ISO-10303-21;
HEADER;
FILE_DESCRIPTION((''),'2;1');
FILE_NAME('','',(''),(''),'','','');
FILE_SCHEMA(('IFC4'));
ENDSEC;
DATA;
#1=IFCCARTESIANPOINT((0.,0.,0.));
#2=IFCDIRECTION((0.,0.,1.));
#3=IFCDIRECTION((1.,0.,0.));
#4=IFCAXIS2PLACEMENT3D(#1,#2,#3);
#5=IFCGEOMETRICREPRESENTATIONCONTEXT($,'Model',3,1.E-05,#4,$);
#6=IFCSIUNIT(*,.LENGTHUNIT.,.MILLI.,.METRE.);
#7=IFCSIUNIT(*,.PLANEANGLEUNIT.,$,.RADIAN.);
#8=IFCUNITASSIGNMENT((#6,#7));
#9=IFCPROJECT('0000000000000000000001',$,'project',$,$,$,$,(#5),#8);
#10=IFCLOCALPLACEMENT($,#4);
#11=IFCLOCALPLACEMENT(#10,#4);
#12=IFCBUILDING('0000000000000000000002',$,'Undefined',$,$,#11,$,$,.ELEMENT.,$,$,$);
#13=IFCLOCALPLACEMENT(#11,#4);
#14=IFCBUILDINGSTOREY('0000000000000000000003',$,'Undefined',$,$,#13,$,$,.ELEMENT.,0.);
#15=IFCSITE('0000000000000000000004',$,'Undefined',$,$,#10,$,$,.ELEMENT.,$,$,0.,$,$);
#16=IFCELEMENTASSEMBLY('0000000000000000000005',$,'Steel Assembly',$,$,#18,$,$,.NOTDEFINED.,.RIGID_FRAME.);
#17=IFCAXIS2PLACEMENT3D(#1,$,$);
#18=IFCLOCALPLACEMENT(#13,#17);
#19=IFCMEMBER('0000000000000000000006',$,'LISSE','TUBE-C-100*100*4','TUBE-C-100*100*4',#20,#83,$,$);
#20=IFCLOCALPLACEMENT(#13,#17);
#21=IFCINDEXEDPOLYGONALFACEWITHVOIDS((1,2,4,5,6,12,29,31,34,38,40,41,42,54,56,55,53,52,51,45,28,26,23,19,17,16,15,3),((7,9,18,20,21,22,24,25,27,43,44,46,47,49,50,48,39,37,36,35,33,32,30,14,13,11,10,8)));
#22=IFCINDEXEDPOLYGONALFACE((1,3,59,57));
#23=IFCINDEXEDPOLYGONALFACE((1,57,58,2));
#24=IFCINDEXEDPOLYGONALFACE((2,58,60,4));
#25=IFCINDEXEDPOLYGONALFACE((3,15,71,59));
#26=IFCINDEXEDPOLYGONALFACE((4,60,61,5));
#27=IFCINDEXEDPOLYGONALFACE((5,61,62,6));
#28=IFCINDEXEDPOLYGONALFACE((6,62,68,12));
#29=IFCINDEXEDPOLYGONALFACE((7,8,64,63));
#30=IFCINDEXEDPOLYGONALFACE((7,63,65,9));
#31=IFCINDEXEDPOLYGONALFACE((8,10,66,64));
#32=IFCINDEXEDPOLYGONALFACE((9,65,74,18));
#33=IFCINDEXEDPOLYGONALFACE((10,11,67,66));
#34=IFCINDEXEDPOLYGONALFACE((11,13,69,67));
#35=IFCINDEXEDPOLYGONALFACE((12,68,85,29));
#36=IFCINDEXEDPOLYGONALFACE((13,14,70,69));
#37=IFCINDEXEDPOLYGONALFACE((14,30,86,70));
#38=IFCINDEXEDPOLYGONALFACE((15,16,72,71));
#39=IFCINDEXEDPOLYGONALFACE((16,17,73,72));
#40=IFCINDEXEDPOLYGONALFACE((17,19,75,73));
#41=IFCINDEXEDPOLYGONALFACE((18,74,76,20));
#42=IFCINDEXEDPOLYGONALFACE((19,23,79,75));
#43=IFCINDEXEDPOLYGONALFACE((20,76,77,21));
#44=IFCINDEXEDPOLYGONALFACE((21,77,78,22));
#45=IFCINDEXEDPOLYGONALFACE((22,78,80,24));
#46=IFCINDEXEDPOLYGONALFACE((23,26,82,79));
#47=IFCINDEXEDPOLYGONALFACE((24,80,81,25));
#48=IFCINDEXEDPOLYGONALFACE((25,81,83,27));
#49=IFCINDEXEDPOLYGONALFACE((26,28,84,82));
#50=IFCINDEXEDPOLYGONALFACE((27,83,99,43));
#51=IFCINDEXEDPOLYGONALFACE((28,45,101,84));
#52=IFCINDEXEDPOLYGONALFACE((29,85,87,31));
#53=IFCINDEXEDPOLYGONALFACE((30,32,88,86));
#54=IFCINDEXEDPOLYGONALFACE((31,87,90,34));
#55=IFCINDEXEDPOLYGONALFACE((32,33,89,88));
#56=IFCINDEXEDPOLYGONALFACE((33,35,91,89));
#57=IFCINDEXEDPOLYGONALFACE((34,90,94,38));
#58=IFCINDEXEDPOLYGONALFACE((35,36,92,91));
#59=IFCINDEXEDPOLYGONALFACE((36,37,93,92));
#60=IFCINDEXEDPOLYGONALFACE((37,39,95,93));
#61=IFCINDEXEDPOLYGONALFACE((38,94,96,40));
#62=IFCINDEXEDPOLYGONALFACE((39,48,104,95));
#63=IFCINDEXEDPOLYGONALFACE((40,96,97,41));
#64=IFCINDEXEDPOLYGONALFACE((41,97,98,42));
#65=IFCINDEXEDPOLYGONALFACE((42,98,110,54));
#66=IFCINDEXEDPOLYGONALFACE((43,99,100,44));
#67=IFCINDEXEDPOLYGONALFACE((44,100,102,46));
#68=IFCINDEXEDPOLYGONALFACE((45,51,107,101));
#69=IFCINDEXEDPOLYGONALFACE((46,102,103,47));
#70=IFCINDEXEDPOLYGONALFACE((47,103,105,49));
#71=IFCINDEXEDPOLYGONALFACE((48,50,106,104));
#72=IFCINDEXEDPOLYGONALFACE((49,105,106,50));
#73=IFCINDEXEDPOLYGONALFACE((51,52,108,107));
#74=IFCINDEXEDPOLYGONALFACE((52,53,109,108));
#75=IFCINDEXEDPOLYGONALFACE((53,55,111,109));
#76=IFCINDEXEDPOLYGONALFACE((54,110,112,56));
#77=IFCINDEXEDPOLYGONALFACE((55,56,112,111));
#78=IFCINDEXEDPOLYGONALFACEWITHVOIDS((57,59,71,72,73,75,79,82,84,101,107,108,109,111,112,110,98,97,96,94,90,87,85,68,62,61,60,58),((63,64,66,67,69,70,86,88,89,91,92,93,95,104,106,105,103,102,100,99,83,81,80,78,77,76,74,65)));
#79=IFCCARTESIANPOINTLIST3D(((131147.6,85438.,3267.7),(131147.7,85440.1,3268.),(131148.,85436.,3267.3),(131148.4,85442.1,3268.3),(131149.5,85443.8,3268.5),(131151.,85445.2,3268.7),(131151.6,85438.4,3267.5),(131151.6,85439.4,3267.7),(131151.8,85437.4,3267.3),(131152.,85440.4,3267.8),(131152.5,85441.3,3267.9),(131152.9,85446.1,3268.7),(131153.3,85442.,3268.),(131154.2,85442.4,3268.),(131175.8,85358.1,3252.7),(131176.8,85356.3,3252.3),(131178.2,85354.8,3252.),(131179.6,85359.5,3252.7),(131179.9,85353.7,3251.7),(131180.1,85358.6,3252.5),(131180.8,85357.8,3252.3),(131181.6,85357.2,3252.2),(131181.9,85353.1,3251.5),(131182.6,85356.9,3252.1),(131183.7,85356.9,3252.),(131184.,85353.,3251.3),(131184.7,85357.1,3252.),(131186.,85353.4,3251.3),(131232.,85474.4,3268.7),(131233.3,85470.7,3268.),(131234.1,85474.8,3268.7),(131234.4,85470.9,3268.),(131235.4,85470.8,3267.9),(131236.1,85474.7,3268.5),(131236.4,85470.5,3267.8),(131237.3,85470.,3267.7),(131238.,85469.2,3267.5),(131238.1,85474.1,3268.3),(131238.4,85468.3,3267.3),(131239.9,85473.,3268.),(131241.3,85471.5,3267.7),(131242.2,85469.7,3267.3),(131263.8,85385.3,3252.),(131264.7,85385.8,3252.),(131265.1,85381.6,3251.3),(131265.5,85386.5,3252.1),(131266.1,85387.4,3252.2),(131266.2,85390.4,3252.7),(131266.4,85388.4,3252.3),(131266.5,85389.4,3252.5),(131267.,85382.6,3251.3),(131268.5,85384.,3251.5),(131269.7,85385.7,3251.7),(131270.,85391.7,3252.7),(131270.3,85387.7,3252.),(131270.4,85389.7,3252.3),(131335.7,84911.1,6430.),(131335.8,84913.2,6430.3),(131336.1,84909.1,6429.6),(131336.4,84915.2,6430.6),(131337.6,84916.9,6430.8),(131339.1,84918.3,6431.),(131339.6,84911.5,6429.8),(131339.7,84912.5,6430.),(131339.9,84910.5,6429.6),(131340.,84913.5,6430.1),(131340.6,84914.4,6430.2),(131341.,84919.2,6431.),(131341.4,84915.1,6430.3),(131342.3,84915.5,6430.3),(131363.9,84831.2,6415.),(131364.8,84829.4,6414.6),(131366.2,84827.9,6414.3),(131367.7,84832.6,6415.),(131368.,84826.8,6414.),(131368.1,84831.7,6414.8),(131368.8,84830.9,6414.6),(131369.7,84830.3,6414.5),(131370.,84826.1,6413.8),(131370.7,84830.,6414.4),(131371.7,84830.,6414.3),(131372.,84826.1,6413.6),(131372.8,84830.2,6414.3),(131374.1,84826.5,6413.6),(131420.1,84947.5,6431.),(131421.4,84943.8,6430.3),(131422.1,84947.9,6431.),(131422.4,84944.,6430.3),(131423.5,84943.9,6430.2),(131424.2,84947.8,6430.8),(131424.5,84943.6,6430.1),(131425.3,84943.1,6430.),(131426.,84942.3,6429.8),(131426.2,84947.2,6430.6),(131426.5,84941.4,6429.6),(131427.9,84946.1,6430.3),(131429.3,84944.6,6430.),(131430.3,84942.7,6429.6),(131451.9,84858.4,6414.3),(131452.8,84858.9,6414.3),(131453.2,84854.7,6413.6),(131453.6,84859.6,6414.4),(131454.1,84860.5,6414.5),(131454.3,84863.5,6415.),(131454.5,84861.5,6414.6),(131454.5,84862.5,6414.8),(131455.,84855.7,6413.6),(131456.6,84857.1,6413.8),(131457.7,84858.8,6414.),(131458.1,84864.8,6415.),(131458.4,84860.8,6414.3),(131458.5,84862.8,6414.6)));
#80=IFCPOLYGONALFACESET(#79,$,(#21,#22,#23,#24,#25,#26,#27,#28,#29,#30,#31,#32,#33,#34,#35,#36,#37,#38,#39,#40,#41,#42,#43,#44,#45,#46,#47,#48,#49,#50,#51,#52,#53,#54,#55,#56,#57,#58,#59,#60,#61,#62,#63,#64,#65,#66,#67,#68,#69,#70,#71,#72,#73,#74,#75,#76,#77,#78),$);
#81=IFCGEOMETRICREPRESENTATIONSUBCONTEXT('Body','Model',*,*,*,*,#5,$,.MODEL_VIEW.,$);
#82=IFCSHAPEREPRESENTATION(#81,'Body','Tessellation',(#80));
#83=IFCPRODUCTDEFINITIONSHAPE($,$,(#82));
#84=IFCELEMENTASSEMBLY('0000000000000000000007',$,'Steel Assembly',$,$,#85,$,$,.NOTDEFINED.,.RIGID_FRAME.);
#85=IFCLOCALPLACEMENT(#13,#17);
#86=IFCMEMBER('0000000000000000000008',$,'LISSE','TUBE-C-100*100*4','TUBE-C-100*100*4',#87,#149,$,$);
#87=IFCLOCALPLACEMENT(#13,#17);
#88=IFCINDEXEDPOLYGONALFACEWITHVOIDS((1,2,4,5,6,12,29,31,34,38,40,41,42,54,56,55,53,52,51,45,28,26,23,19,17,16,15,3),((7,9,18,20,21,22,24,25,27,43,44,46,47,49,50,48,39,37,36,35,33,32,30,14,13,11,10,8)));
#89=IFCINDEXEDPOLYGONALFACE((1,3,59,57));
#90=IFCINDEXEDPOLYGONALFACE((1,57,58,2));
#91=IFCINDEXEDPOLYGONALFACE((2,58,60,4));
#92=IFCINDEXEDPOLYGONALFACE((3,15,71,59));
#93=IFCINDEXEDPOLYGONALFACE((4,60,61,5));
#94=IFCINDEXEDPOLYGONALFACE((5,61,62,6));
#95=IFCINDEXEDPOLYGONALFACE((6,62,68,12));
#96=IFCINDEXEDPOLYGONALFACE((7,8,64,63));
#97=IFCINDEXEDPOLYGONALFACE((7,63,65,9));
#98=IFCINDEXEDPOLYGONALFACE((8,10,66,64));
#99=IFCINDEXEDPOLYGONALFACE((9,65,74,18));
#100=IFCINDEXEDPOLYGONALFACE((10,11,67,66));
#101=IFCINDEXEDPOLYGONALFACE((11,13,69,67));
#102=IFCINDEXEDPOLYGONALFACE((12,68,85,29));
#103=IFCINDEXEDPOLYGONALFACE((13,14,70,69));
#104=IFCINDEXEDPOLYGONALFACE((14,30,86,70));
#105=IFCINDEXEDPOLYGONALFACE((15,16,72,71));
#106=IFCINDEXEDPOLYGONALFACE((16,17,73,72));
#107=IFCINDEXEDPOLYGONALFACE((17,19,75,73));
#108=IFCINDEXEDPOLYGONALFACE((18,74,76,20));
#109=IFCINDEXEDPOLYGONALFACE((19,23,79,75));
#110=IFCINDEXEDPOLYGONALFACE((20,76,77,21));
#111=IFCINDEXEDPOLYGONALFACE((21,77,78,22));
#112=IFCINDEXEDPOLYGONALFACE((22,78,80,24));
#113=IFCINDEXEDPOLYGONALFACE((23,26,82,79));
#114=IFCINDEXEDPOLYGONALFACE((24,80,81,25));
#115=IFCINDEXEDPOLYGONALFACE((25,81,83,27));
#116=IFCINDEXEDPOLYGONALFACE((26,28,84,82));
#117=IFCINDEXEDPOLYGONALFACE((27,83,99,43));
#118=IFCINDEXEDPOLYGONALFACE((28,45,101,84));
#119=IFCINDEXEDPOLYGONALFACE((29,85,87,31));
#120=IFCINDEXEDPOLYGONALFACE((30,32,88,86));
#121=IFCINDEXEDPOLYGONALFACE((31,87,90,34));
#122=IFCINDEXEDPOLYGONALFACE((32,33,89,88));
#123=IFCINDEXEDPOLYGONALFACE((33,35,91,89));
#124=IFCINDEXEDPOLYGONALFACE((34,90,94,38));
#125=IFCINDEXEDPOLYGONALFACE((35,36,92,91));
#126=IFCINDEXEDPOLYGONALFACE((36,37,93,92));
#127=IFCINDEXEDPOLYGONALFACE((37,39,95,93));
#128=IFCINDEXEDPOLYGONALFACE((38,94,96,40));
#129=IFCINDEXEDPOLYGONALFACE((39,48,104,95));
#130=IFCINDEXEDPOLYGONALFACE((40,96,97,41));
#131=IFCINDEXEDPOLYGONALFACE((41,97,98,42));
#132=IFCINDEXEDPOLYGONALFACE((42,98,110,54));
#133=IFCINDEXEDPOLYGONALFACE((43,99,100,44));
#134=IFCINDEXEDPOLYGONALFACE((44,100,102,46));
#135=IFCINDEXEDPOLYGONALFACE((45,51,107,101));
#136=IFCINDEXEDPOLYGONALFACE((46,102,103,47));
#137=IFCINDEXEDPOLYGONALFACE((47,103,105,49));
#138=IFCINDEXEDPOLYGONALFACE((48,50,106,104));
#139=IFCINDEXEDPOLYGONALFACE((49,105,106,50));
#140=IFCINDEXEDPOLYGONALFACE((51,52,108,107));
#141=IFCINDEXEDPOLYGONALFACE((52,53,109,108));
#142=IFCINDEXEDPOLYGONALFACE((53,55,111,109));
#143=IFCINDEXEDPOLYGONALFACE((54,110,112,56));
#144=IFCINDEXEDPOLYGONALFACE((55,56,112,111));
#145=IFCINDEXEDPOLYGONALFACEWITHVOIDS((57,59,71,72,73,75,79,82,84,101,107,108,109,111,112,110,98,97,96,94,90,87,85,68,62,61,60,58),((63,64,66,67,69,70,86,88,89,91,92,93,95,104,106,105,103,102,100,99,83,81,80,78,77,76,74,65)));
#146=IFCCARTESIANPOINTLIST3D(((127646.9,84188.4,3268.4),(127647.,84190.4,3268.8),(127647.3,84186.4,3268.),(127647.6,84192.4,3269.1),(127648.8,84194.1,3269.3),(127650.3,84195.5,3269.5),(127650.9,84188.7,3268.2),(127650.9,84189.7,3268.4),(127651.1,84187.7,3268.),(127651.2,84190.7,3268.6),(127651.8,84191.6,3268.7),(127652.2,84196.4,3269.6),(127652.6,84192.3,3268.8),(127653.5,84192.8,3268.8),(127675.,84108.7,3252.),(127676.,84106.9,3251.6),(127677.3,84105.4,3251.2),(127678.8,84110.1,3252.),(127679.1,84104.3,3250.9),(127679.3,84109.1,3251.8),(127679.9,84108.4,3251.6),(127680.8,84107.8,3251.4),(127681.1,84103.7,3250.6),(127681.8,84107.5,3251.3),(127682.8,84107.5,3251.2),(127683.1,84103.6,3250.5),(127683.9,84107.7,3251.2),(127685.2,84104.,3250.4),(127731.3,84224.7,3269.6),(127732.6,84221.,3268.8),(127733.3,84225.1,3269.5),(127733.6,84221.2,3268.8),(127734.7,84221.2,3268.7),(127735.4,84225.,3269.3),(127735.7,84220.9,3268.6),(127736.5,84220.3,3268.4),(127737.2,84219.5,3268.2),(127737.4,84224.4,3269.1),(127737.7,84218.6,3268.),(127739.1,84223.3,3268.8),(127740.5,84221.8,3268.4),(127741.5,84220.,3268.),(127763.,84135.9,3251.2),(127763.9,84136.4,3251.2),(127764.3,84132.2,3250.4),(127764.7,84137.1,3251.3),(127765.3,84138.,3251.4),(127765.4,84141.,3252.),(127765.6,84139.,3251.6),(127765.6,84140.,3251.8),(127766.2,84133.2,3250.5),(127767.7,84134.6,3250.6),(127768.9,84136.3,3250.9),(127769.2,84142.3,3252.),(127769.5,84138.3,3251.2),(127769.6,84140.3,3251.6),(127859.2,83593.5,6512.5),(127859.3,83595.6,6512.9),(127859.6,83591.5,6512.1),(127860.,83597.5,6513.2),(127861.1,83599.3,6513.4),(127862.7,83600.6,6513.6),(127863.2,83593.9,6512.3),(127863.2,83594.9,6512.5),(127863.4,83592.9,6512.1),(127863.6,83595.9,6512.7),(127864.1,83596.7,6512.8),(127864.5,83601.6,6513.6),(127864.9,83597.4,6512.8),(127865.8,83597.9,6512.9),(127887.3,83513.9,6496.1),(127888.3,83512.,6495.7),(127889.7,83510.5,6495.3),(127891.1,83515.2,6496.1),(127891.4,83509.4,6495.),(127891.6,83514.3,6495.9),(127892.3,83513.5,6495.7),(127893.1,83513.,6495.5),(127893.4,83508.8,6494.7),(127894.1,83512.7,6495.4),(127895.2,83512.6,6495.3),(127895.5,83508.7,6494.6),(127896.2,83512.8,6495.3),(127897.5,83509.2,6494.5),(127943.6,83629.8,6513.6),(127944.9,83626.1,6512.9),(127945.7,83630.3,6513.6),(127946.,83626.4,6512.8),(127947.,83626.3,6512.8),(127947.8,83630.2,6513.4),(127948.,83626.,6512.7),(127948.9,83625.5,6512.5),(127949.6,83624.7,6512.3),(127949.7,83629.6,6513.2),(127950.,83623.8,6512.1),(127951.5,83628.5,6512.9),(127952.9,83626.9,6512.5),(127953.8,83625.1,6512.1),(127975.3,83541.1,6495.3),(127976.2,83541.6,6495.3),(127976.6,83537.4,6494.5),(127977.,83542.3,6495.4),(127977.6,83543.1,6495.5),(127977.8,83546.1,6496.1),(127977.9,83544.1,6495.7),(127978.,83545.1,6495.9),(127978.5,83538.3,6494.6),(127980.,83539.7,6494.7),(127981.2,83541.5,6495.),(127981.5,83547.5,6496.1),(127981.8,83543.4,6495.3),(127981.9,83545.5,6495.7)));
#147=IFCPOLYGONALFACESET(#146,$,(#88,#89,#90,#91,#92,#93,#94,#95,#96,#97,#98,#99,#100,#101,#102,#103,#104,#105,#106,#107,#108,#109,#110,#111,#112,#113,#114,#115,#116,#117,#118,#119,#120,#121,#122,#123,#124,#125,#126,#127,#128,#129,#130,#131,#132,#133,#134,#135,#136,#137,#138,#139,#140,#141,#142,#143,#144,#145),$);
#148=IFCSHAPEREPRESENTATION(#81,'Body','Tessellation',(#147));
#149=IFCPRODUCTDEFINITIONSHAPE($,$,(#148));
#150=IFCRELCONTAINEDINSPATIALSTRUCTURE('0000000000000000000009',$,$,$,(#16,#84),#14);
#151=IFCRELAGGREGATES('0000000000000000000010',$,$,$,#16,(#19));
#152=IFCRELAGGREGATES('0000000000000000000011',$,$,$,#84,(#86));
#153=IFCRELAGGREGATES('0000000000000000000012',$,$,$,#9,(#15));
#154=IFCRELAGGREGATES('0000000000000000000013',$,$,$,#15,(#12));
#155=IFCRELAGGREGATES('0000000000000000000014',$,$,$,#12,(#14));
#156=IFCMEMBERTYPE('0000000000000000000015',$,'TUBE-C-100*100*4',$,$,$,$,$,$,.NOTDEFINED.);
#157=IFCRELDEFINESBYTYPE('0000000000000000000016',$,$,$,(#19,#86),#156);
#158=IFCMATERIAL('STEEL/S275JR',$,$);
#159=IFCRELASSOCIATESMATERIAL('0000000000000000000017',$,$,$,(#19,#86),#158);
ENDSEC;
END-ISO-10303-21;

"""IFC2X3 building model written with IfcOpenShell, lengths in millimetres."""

from ifc_helpers import new_model, si_unit, frame, origin_with_axes, origin_2d_with_axis, place, context, subcontext, project, spatial, hollow_rectangle, extrude, material, type_object, element, aggregate, save


model = new_model("IFC2X3")

# Units and contexts
model_context = context("Model", 3, precision=1e-05, world=origin_with_axes())
body_context = subcontext(model_context, "Body", "Model", "MODEL_VIEW")
ifc_project = project(units=[si_unit("LENGTHUNIT", "METRE", prefix="MILLI"), si_unit("PLANEANGLEUNIT", "RADIAN")], contexts=[model_context])

# Site, building, storey
site_placement = place(None, origin_with_axes())
site = spatial("IfcSite", under=ifc_project, at=site_placement, Name="Undefined", CompositionType="ELEMENT", RefElevation=0.0)
building_placement = place(site_placement, origin_with_axes())
building = spatial("IfcBuilding", under=site, at=building_placement, Name="Undefined", CompositionType="ELEMENT")
storey_placement = place(building_placement, origin_with_axes())
storey = spatial("IfcBuildingStorey", under=building, at=storey_placement, Name="Undefined", CompositionType="ELEMENT", Elevation=0.0)

# Shared definitions
ifc_material = material(Name="STEEL/S275JR")

# Element assemblies, members
member_type = type_object("IfcMemberType", Name="TUBE-C-100*100*4", PredefinedType="NOTDEFINED")
assembly_1_placement = place(storey_placement, origin_with_axes())
assembly_1 = element("IfcElementAssembly", 1, at=assembly_1_placement, inside=storey, Name="Steel Assembly", AssemblyPlace="NOTDEFINED", PredefinedType="RIGID_FRAME")
member_1_placement = place(assembly_1_placement, frame((131397.1, 84887.0, 6422.3), z_axis=(0.941802, 0.336168, 0.000001), x_axis=(-0.058563, 0.164072, -0.984708)))
member_1 = element("IfcMember", 2, at=member_1_placement, type_object=member_type, material=ifc_material, Name="LISSE", Description="TUBE-C-100*100*4", ObjectType="TUBE-C-100*100*4", context=body_context, shape_type="SweptSolid", body=[
    extrude(hollow_rectangle(XDim=100.0, YDim=100.0, WallThickness=4.0, InnerFilletRadius=4.0, OuterFilletRadius=8.0, at=origin_2d_with_axis()), frame((3211.4, 0.0, 0.0), z_axis=(-1.0, 0.0, 0.0), x_axis=(0.0, -1.0, 0.0)), (0.0, 0.0, 1.0), 3211.4),
])
aggregate(assembly_1, [member_1])
assembly_2_placement = place(storey_placement, origin_with_axes())
assembly_2 = element("IfcElementAssembly", 3, at=assembly_2_placement, inside=storey, Name="Steel Assembly", AssemblyPlace="NOTDEFINED", PredefinedType="RIGID_FRAME")
member_2_placement = place(assembly_2_placement, frame((127920.6, 83569.5, 6504.0), z_axis=(0.941802, 0.336168, 0.0), x_axis=(-0.064244, 0.179986, -0.981569)))
member_2 = element("IfcMember", 4, at=member_2_placement, type_object=member_type, material=ifc_material, Name="LISSE", Description="TUBE-C-100*100*4", ObjectType="TUBE-C-100*100*4", context=body_context, shape_type="SweptSolid", body=[
    extrude(hollow_rectangle(XDim=100.0, YDim=100.0, WallThickness=4.0, InnerFilletRadius=4.0, OuterFilletRadius=8.0, at=origin_2d_with_axis()), frame((3305.0, 0.0, 0.0), z_axis=(-1.0, 0.0, 0.0), x_axis=(0.0, -1.0, 0.0)), (0.0, 0.0, 1.0), 3305.0),
])
aggregate(assembly_2, [member_2])

save(model, "model.ifc")
